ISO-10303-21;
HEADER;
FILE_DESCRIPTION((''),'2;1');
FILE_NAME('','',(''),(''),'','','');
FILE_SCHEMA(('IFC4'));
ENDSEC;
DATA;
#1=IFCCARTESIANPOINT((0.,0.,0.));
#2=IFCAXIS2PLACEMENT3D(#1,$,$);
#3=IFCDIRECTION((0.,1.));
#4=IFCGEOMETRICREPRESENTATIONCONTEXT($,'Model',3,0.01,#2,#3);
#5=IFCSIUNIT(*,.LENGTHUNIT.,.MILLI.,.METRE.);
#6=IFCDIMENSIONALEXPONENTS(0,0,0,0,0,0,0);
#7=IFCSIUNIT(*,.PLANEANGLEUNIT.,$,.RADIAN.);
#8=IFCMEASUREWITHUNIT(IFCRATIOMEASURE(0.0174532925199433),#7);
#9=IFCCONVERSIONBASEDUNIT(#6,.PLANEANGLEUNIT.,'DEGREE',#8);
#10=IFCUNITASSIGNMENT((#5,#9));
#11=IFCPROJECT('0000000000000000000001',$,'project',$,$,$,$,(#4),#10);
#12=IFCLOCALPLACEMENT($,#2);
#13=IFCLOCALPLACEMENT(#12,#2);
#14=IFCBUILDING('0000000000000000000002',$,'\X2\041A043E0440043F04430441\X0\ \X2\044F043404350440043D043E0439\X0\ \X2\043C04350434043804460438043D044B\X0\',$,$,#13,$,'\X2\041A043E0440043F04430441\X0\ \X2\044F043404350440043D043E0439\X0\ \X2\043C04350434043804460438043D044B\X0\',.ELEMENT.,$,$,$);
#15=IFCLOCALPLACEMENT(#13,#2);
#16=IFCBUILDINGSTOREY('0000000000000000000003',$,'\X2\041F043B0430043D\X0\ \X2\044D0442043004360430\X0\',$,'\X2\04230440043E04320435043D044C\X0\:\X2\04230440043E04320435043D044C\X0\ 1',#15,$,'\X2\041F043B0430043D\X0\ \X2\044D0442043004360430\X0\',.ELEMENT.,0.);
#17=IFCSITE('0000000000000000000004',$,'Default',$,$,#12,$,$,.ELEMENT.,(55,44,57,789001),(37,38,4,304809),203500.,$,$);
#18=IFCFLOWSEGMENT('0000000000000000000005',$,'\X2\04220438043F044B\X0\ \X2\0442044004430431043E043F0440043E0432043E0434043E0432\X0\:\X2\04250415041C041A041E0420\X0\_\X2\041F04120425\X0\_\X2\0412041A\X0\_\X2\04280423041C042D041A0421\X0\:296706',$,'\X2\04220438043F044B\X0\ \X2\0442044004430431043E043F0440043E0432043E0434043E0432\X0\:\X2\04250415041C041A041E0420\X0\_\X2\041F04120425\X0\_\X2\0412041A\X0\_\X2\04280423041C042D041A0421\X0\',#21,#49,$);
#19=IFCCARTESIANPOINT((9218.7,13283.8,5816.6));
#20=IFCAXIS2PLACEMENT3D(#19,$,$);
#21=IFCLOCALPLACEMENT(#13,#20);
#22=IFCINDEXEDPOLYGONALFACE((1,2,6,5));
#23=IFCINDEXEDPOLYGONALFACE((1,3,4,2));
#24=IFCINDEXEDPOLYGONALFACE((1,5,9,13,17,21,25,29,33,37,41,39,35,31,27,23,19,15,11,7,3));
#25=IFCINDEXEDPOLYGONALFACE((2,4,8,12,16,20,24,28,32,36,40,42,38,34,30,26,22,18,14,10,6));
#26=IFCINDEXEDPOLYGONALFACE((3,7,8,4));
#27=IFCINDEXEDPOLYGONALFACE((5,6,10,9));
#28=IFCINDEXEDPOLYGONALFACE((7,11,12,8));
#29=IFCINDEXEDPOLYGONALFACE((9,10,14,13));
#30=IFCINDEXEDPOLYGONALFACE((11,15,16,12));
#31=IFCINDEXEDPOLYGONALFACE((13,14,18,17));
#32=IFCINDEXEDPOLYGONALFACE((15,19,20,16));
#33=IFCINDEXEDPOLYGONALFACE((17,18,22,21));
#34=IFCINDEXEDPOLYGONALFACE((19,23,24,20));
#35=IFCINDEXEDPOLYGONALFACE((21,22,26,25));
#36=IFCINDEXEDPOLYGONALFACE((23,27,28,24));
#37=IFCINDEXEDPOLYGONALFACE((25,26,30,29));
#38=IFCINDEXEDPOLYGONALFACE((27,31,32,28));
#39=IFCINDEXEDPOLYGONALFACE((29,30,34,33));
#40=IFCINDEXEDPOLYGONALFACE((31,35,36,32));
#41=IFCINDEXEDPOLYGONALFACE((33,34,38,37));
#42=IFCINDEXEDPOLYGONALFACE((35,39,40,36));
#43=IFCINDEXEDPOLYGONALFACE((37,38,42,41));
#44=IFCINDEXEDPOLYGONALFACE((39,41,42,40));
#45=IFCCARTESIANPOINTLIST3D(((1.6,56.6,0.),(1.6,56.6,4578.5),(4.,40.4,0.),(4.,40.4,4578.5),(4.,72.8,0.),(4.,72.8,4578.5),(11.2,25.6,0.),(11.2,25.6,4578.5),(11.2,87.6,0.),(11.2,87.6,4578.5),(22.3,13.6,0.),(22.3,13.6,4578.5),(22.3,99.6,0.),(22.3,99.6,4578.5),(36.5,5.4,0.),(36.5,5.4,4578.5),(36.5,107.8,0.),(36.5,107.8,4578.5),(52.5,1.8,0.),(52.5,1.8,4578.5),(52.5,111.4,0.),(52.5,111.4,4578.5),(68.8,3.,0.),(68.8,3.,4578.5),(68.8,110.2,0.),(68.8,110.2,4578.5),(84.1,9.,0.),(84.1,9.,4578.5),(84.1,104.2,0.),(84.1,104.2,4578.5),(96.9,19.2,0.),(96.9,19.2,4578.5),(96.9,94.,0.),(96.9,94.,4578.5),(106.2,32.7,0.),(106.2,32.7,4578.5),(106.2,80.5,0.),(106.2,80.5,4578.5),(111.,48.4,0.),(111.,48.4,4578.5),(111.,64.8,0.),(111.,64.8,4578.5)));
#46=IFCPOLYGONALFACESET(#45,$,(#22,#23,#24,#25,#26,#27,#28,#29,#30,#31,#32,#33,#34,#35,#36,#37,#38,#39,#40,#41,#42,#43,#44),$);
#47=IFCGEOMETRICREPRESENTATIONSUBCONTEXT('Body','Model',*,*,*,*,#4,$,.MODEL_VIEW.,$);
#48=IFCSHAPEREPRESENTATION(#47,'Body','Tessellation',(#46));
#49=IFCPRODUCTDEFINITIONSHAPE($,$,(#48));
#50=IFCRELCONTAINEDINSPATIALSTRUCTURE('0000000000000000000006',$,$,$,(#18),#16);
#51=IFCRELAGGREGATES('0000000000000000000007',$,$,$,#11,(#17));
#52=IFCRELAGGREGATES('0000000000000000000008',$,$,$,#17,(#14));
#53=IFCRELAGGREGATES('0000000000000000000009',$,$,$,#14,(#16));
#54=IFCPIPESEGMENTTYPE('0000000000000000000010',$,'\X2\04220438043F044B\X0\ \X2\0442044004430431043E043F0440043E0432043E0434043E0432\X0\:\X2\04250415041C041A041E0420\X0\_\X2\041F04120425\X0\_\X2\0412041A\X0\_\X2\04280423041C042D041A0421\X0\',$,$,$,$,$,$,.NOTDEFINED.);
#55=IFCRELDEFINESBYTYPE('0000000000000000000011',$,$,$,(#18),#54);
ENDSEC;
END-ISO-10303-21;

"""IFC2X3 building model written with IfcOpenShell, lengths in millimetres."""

from ifc_helpers import new_model, entity, si_unit, converted_unit, direction, frame, origin, origin_2d_with_axis, place, context, subcontext, project, spatial, circle, extrude, type_object, element, save


model = new_model("IFC2X3")

# Units and contexts
model_context = context("Model", 3, precision=0.01, world=origin(), true_north=direction((0.0, 1.0)))
body_context = subcontext(model_context, "Body", "Model", "MODEL_VIEW")
ifc_project = project(units=[si_unit("LENGTHUNIT", "METRE", prefix="MILLI"), converted_unit("PLANEANGLEUNIT", "DEGREE", entity("IfcRatioMeasure", 0.0174532925199433), si_unit("PLANEANGLEUNIT", "RADIAN"), dimensions=[0, 0, 0, 0, 0, 0, 0])], contexts=[model_context])

# Site, building, storey
site_placement = place(None, origin())
site = spatial("IfcSite", under=ifc_project, at=site_placement, Name="Default", CompositionType="ELEMENT", RefLatitude=(55, 44, 57, 789001), RefLongitude=(37, 38, 4, 304809), RefElevation=203500.0)
building_placement = place(site_placement, origin())
building = spatial("IfcBuilding", under=site, at=building_placement, Name="Корпус ядерной медицины", LongName="Корпус ядерной медицины", CompositionType="ELEMENT")
storey_placement = place(building_placement, origin())
storey = spatial("IfcBuildingStorey", under=building, at=storey_placement, Name="План этажа", ObjectType="Уровень:Уровень 1", LongName="План этажа", CompositionType="ELEMENT", Elevation=0.0)

# Flow segment
pipe_segment_type = type_object("IfcPipeSegmentType", Name="Типы трубопроводов:ХЕМКОР_ПВХ_ВК_ШУМЭКС", PredefinedType="NOTDEFINED")
flow_segment_placement = place(building_placement, frame((9218.7, 13283.8, 5816.6)))
element("IfcFlowSegment", 1, at=flow_segment_placement, inside=storey, type_object=pipe_segment_type, Name="Типы трубопроводов:ХЕМКОР_ПВХ_ВК_ШУМЭКС:296706", ObjectType="Типы трубопроводов:ХЕМКОР_ПВХ_ВК_ШУМЭКС", context=body_context, shape_type="SweptSolid", body=[
    extrude(circle(Radius=55.0, at=origin_2d_with_axis()), frame((56.6, 56.6, 0.0), z_axis=(0.0, 0.0, 1.0), x_axis=(-1.0, 0.0, 0.0)), (0.0, 0.0, 1.0), 4578.5),
])

save(model, "model.ifc")
